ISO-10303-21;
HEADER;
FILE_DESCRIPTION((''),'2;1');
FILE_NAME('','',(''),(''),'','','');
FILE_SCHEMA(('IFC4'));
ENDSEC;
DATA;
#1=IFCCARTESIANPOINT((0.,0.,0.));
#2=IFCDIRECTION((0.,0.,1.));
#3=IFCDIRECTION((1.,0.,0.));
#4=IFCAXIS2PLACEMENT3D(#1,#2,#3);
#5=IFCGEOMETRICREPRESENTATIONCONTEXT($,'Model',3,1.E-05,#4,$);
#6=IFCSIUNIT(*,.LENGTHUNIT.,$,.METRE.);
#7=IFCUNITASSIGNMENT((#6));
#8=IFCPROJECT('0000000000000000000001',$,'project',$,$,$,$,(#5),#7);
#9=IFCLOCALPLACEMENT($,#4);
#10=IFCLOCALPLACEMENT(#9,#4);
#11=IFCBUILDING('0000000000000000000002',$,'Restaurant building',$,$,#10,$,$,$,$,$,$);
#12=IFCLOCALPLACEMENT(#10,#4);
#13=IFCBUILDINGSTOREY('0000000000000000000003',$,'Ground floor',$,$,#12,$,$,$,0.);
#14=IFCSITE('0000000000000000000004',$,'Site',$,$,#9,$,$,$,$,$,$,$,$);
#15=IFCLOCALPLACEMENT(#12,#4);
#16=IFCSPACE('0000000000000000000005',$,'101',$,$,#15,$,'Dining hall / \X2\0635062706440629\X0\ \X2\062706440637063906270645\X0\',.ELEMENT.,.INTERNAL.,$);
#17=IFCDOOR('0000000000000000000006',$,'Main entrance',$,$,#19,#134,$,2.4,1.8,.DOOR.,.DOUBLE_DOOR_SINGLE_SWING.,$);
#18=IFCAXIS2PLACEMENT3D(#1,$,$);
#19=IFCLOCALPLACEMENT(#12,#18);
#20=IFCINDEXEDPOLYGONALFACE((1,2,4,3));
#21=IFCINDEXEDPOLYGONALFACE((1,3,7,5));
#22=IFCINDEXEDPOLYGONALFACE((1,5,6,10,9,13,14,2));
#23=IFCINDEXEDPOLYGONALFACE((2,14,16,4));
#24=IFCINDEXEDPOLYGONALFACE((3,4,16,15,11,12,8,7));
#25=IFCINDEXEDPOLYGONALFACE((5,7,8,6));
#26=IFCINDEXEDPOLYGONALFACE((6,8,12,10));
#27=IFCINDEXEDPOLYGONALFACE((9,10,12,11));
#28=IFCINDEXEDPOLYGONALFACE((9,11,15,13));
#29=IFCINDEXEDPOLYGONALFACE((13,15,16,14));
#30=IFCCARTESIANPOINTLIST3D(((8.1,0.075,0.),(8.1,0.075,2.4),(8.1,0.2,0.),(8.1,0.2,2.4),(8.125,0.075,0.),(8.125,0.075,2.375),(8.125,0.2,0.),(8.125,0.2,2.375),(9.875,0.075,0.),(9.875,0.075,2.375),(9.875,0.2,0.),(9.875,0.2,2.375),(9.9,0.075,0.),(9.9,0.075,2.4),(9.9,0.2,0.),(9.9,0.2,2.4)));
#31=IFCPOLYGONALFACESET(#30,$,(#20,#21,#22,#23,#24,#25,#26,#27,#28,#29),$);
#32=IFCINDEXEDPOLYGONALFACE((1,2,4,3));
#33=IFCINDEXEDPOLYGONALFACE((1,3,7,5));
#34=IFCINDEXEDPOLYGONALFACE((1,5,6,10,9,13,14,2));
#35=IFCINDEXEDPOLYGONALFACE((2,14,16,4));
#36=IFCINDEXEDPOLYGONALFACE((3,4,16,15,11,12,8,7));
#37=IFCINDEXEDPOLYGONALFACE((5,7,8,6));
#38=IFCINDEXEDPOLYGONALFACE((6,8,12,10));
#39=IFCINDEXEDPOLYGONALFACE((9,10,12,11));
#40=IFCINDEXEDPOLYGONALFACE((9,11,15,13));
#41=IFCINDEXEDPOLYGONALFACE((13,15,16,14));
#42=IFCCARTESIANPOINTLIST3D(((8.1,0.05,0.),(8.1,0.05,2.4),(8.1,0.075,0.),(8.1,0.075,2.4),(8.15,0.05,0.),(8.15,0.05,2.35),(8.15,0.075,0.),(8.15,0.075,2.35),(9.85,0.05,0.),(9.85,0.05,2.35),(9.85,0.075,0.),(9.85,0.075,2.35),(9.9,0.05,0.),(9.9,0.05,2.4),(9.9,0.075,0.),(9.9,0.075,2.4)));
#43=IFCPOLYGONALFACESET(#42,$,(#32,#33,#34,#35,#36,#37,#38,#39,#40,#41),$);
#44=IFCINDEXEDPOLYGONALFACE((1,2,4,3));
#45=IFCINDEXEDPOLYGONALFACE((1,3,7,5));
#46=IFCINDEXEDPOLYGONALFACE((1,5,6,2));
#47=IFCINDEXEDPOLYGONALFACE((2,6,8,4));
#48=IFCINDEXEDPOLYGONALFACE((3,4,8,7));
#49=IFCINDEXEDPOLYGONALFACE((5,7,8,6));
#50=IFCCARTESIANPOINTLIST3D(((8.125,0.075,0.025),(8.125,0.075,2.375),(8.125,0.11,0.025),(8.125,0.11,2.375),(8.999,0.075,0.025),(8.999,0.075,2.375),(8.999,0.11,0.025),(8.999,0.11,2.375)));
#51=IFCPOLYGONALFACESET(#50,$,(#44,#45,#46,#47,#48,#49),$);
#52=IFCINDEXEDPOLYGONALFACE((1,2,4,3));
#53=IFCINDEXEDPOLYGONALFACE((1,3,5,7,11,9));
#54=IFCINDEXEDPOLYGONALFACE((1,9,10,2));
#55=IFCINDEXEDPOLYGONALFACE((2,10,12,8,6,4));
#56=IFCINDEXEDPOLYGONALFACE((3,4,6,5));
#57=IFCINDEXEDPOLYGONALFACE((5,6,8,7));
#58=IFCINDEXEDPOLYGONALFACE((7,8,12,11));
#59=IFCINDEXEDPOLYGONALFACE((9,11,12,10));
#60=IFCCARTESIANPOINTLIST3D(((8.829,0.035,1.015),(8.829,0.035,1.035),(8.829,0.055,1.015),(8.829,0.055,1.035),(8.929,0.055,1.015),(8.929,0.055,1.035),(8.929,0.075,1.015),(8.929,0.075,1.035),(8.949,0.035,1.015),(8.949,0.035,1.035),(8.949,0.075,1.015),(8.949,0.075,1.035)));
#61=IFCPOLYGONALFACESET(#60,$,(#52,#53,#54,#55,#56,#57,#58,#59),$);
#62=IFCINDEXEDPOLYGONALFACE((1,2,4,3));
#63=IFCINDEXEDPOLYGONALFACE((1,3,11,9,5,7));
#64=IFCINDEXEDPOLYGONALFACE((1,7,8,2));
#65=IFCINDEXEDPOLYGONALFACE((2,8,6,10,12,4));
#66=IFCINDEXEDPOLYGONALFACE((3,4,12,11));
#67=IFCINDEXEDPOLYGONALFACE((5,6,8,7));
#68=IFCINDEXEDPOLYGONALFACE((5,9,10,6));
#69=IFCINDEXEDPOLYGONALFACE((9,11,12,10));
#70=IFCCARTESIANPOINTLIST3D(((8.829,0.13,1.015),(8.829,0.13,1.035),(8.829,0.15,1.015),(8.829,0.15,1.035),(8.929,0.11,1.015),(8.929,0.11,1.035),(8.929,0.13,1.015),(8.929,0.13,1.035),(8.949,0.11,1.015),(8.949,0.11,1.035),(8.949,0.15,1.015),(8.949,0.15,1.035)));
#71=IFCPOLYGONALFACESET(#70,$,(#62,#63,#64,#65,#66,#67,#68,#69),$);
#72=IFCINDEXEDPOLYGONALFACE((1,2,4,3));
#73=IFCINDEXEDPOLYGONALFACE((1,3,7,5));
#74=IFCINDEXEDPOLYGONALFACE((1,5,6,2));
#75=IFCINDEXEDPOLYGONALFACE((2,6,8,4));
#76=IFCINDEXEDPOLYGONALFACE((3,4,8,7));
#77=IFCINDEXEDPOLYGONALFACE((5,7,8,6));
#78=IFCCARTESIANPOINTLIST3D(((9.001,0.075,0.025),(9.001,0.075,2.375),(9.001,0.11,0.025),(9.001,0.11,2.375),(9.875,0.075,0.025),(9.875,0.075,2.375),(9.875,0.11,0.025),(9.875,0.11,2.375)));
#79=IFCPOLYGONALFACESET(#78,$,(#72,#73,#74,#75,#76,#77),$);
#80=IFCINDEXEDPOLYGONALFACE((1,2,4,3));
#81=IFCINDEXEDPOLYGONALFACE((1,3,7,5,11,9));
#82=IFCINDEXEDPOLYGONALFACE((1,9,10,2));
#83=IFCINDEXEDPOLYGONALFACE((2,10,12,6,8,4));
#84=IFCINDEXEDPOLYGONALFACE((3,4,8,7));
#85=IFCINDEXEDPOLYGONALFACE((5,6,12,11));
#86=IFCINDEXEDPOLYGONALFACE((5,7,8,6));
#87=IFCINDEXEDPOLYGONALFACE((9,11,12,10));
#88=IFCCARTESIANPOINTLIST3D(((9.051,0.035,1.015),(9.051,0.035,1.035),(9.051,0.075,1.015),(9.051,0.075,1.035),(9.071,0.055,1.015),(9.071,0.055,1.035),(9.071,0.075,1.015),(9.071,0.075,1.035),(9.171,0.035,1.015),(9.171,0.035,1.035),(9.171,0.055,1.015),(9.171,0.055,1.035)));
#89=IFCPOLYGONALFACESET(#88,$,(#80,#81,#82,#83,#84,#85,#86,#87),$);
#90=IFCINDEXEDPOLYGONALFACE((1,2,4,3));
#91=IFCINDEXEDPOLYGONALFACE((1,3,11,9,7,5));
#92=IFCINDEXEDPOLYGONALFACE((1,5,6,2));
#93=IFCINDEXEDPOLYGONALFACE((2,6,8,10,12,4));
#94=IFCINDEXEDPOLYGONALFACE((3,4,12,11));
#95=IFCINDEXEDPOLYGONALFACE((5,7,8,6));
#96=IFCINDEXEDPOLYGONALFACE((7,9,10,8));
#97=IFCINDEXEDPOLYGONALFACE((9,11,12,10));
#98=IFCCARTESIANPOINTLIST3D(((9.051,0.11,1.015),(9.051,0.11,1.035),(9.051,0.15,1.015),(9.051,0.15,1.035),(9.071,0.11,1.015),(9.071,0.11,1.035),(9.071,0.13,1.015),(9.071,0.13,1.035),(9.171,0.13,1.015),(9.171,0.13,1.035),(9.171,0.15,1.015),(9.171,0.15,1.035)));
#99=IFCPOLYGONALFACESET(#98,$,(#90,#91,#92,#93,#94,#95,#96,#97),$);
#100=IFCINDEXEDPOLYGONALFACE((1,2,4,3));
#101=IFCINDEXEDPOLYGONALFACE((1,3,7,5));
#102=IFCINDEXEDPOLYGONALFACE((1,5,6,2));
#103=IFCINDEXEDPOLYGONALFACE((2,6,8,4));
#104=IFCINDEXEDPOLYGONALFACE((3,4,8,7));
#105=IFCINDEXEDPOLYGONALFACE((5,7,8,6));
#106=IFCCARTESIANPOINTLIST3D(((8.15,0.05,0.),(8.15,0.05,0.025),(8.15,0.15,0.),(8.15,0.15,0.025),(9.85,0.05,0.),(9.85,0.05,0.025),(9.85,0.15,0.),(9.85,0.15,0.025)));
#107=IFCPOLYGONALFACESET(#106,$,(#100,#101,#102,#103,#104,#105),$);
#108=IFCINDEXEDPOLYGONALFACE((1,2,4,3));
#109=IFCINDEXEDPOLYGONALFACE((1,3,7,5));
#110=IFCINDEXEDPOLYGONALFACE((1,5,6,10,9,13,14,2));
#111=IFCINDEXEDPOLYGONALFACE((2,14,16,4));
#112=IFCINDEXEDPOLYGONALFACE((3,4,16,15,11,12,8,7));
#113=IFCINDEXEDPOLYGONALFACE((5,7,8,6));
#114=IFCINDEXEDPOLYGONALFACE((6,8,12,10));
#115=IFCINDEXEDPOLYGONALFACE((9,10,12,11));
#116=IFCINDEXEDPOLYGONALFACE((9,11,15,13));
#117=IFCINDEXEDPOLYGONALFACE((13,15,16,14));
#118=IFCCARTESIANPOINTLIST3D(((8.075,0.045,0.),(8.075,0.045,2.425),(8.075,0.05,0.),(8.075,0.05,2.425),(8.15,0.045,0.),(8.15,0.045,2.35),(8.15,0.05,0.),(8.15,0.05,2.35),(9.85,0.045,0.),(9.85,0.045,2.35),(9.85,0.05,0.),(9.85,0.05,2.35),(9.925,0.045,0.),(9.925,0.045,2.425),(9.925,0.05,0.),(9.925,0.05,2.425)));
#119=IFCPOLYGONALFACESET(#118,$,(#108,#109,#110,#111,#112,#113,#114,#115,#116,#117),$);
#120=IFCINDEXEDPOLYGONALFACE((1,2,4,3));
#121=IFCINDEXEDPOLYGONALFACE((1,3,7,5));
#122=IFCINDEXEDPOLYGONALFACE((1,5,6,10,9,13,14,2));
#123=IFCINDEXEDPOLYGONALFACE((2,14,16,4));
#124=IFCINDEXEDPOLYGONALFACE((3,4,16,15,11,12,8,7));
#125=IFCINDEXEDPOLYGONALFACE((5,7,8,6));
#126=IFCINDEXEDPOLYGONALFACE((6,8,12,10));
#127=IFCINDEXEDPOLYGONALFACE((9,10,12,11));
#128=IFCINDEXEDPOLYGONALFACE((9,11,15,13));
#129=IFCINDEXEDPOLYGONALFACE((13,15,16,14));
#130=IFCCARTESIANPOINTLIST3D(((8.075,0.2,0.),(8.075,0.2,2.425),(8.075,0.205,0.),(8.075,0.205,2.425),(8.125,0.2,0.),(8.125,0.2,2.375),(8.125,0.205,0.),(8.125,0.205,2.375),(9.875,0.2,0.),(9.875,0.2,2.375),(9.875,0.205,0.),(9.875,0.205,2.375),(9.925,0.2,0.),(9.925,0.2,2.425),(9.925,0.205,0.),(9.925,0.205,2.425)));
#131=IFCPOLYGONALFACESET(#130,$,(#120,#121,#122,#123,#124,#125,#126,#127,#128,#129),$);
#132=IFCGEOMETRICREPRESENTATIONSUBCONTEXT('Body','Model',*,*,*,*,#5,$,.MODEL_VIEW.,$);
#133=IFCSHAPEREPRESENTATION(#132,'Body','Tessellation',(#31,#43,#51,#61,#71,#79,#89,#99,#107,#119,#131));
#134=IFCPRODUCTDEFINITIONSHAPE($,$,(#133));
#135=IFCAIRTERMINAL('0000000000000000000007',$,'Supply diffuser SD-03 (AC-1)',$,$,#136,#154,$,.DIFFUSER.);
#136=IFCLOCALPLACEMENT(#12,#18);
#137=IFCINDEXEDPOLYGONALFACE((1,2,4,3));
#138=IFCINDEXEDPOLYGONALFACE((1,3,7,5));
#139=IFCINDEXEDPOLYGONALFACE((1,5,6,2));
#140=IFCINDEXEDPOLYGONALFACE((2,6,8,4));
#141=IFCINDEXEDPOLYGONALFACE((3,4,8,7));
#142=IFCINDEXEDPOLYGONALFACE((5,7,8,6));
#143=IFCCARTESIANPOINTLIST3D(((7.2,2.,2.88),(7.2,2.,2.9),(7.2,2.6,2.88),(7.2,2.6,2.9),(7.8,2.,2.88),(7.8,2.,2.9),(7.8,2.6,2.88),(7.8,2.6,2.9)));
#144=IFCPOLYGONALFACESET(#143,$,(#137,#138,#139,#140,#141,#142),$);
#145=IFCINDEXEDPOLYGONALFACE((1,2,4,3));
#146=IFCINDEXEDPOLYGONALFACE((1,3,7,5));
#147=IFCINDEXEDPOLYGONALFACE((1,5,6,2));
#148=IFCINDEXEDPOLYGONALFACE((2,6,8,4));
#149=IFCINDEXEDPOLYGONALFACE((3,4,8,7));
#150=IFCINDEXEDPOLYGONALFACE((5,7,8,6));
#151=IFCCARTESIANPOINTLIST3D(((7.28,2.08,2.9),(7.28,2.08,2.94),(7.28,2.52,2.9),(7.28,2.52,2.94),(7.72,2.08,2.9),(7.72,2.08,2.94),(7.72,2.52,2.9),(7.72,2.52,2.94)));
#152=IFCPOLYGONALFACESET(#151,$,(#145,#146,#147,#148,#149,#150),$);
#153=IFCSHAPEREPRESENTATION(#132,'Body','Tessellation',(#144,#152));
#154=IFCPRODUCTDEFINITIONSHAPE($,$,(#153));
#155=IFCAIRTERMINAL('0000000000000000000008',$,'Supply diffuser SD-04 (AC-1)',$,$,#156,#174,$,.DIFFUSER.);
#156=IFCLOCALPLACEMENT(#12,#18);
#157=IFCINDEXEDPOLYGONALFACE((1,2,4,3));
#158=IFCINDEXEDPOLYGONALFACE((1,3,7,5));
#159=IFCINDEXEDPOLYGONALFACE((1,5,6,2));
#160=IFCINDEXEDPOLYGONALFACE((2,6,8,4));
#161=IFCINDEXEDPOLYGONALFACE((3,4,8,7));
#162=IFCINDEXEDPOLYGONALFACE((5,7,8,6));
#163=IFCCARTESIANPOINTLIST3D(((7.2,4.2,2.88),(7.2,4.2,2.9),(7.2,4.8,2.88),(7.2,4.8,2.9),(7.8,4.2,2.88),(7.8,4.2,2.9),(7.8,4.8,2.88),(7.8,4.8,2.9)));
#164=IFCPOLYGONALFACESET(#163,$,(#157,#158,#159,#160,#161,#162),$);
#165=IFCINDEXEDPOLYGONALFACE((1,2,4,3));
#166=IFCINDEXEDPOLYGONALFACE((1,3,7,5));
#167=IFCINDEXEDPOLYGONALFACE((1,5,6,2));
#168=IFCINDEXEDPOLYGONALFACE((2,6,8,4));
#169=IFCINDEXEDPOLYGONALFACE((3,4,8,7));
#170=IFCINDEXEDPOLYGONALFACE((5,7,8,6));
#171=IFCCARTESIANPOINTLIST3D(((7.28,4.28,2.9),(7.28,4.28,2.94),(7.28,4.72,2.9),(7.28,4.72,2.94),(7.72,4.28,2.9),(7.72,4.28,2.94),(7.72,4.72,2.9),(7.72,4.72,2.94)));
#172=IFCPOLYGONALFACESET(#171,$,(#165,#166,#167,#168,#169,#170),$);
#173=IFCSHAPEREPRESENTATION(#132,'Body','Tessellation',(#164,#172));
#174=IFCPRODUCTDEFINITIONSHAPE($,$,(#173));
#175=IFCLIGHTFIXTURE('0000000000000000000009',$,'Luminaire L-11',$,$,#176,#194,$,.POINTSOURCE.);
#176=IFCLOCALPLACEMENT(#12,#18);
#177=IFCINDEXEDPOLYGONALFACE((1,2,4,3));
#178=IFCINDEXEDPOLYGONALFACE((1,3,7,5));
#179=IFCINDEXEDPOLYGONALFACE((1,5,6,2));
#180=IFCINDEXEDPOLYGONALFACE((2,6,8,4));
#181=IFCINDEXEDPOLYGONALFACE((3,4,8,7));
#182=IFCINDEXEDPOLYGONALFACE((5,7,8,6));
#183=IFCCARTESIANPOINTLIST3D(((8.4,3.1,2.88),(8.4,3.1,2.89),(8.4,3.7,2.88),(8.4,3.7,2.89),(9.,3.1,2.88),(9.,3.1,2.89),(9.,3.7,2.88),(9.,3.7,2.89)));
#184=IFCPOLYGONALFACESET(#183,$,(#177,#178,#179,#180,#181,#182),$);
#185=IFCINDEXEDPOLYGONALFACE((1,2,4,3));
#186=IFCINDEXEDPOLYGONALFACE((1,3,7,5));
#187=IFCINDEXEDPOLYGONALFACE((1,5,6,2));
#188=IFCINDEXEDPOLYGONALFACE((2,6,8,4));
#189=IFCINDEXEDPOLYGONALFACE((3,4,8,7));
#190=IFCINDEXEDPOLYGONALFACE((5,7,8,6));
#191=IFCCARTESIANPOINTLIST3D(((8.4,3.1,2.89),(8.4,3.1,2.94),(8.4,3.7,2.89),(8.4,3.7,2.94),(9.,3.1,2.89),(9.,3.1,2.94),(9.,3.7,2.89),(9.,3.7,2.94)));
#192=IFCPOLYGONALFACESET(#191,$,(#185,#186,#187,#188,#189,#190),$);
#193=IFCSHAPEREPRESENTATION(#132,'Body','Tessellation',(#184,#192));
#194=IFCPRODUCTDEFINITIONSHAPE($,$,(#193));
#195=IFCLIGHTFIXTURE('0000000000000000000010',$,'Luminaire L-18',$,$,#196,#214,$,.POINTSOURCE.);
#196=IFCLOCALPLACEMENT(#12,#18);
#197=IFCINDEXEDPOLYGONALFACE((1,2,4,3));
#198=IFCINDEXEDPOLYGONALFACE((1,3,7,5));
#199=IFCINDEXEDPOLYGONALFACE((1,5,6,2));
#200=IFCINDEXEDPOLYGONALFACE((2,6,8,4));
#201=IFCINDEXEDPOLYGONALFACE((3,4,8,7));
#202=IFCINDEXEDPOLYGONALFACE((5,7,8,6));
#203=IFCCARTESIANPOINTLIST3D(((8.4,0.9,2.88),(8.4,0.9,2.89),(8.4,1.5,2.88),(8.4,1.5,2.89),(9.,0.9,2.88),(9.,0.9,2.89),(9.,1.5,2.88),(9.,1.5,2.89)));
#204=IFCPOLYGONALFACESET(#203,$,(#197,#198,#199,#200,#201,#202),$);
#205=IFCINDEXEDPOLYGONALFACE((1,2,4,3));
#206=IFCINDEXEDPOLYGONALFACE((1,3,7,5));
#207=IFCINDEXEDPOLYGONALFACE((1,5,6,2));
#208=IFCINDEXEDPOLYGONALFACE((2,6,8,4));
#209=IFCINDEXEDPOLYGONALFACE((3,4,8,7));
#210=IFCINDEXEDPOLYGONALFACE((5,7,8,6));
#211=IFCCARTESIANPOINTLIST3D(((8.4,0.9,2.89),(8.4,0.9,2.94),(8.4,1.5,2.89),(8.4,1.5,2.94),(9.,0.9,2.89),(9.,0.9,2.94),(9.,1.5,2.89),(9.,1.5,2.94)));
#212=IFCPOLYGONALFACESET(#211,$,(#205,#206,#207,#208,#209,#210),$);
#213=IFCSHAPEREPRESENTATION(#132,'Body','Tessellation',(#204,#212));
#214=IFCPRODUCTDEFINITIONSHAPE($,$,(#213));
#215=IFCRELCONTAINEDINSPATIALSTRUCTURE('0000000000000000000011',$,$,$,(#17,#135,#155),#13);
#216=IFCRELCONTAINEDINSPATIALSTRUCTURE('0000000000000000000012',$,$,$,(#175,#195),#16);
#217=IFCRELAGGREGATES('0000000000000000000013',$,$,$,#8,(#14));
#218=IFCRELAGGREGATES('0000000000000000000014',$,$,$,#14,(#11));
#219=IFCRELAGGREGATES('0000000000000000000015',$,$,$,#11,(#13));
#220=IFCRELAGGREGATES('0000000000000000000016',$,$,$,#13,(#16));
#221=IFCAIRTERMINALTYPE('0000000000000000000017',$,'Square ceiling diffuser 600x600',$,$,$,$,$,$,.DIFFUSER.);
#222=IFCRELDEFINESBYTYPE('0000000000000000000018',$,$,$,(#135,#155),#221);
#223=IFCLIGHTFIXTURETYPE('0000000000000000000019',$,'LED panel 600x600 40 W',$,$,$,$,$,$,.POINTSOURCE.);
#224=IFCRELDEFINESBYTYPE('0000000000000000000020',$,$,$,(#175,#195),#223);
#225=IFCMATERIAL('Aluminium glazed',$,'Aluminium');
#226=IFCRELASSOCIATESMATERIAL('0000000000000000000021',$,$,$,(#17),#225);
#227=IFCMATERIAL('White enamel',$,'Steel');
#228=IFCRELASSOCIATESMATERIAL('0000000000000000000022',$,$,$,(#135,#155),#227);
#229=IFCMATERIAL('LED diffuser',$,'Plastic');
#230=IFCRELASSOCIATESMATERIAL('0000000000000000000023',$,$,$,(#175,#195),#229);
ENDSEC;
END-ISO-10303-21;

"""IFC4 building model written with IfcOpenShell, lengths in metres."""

from ifc_helpers import new_model, si_unit, frame, origin, origin_with_axes, origin_2d, place, context, subcontext, project, spatial, line, indexed_curve, rectangle, outline, extrude, source, transform, mapped, material, type_object, type_shapes, element, save


model = new_model("IFC4")

# Units and contexts
model_context = context("Model", 3, precision=1e-05, world=origin_with_axes())
body_context = subcontext(model_context, "Body", "Model", "MODEL_VIEW")
ifc_project = project(units=[si_unit("LENGTHUNIT", "METRE")], contexts=[model_context])

# Site, building, storey
site_placement = place(None, origin_with_axes())
site = spatial("IfcSite", under=ifc_project, at=site_placement, Name="Site")
building_placement = place(site_placement, origin_with_axes())
building = spatial("IfcBuilding", under=site, at=building_placement, Name="Restaurant building")
storey_placement = place(building_placement, origin_with_axes())
storey = spatial("IfcBuildingStorey", under=building, at=storey_placement, Name="Ground floor", Elevation=0.0)

# Door
ifc_material_1 = material(Name="Aluminium glazed", Category="Aluminium")
door_placement = place(storey_placement, frame((8.1, 0.05, 0.0)))
element("IfcDoor", 1, at=door_placement, inside=storey, material=ifc_material_1, Name="Main entrance", OperationType="DOUBLE_DOOR_SINGLE_SWING", OverallHeight=2.4, OverallWidth=1.8, PredefinedType="DOOR", context=body_context, shape_type="SweptSolid", body=[
    extrude(outline(indexed_curve([(0.0, 0.0), (0.0, 2.4), (1.8, 2.4), (1.8, 0.0), (1.775, 0.0), (1.775, 2.375), (0.025, 2.375), (0.025, 0.0)], segments=[line(1, 2, 3, 4, 5, 6, 7, 8, 1)])), frame((0.0, 0.025, 0.0), z_axis=(0.0, -1.0, 0.0), x_axis=(1.0, 0.0, 0.0)), (0.0, 0.0, -1.0), 0.125),
    extrude(outline(indexed_curve([(0.0, 0.0), (0.0, 2.4), (1.8, 2.4), (1.8, 0.0), (1.75, 0.0), (1.75, 2.35), (0.05, 2.35), (0.05, 0.0)], segments=[line(1, 2, 3, 4, 5, 6, 7, 8, 1)])), frame((0.0, 0.0, 0.0), z_axis=(0.0, -1.0, 0.0), x_axis=(1.0, 0.0, 0.0)), (0.0, 0.0, -1.0), 0.025),
    extrude(outline(indexed_curve([(0.0, 0.0), (0.874, 0.0), (0.874, 0.035), (0.0, 0.035)], segments=[line(1, 2, 3, 4, 1)])), frame((0.025, 0.025, 0.025), z_axis=(0.0, 0.0, 1.0), x_axis=(1.0, 0.0, 0.0)), (0.0, 0.0, 1.0), 2.35),
    extrude(outline(indexed_curve([(0.0, 0.0), (0.0, -0.04), (-0.12, -0.04), (-0.12, -0.02), (-0.02, -0.02), (-0.02, 0.0)], segments=[line(1, 2, 3, 4, 5, 6, 1)])), frame((0.849, 0.025, 1.015), z_axis=(0.0, 0.0, 1.0), x_axis=(1.0, 0.0, 0.0)), (0.0, 0.0, 1.0), 0.02),
    extrude(outline(indexed_curve([(0.0, 0.0), (0.0, 0.04), (-0.12, 0.04), (-0.12, 0.02), (-0.02, 0.02), (-0.02, 0.0)], segments=[line(1, 2, 3, 4, 5, 6, 1)])), frame((0.849, 0.06, 1.015), z_axis=(0.0, 0.0, 1.0), x_axis=(1.0, 0.0, 0.0)), (0.0, 0.0, 1.0), 0.02),
    extrude(outline(indexed_curve([(0.0, 0.0), (-0.874, 0.0), (-0.874, 0.035), (0.0, 0.035)], segments=[line(1, 2, 3, 4, 1)])), frame((1.775, 0.025, 0.025), z_axis=(0.0, 0.0, 1.0), x_axis=(1.0, 0.0, 0.0)), (0.0, 0.0, 1.0), 2.35),
    extrude(outline(indexed_curve([(0.0, 0.0), (0.0, -0.04), (0.12, -0.04), (0.12, -0.02), (0.02, -0.02), (0.02, 0.0)], segments=[line(1, 2, 3, 4, 5, 6, 1)])), frame((0.951, 0.025, 1.015), z_axis=(0.0, 0.0, 1.0), x_axis=(1.0, 0.0, 0.0)), (0.0, 0.0, 1.0), 0.02),
    extrude(outline(indexed_curve([(0.0, 0.0), (0.0, 0.04), (0.12, 0.04), (0.12, 0.02), (0.02, 0.02), (0.02, 0.0)], segments=[line(1, 2, 3, 4, 5, 6, 1)])), frame((0.951, 0.06, 1.015), z_axis=(0.0, 0.0, 1.0), x_axis=(1.0, 0.0, 0.0)), (0.0, 0.0, 1.0), 0.02),
    extrude(outline(indexed_curve([(0.0, 0.0), (1.7, 0.0), (1.7, 0.1), (0.0, 0.1)], segments=[line(1, 2, 3, 4, 1)])), frame((0.05, 0.0, 0.0), z_axis=(0.0, 0.0, 1.0), x_axis=(1.0, 0.0, 0.0)), (0.0, 0.0, 1.0), 0.025),
    extrude(outline(indexed_curve([(0.0, 0.0), (0.0, 2.425), (1.85, 2.425), (1.85, 0.0), (1.775, 0.0), (1.775, 2.35), (0.075, 2.35), (0.075, 0.0)], segments=[line(1, 2, 3, 4, 5, 6, 7, 8, 1)])), frame((-0.025, -0.005, 0.0), z_axis=(0.0, -1.0, 0.0), x_axis=(1.0, 0.0, 0.0)), (0.0, 0.0, -1.0), 0.005),
    extrude(outline(indexed_curve([(0.0, 0.0), (0.0, 2.425), (1.85, 2.425), (1.85, 0.0), (1.8, 0.0), (1.8, 2.375), (0.05, 2.375), (0.05, 0.0)], segments=[line(1, 2, 3, 4, 5, 6, 7, 8, 1)])), frame((-0.025, 0.15, 0.0), z_axis=(0.0, -1.0, 0.0), x_axis=(1.0, 0.0, 0.0)), (0.0, 0.0, -1.0), 0.005),
])

# Air terminals
ifc_material_2 = material(Name="White enamel", Category="Steel")
air_terminal_type = type_object("IfcAirTerminalType", Name="Square ceiling diffuser 600x600", PredefinedType="DIFFUSER")
shared_shape_1 = source(origin(), body_context, "Body", "SweptSolid", [
    extrude(rectangle(XDim=0.6, YDim=0.6, at=origin_2d()), frame((0.0, 0.0, -0.06)), (0.0, 0.0, 1.0), 0.02),
    extrude(rectangle(XDim=0.44, YDim=0.44, at=origin_2d()), frame((0.0, 0.0, -0.04)), (0.0, 0.0, 1.0), 0.04),
])
type_shapes(air_terminal_type, [shared_shape_1])
for number, where, name in (
    (2, (7.5, 2.3, 2.94), "Supply diffuser SD-03 (AC-1)"),
    (3, (7.5, 4.5, 2.94), "Supply diffuser SD-04 (AC-1)"),
):
    element("IfcAirTerminal", number, at=place(storey_placement, frame(where)), inside=storey, type_object=air_terminal_type, material=ifc_material_2, Name=name, PredefinedType="DIFFUSER", context=body_context, shape_type="MappedRepresentation", body=[
        mapped(shared_shape_1, transform((0.0, 0.0, 0.0))),
    ])

# Shared definitions
space_placement = place(storey_placement, origin_with_axes())
space = spatial("IfcSpace", under=storey, at=space_placement, Name="101", LongName="Dining hall / صالة الطعام", CompositionType="ELEMENT", PredefinedType="INTERNAL")

# Light fixtures
ifc_material_3 = material(Name="LED diffuser", Category="Plastic")
light_fixture_type = type_object("IfcLightFixtureType", Name="LED panel 600x600 40 W", PredefinedType="POINTSOURCE")
shared_shape_2 = source(origin(), body_context, "Body", "SweptSolid", [
    extrude(rectangle(XDim=0.6, YDim=0.6, at=origin_2d()), frame((0.0, 0.0, -0.06)), (0.0, 0.0, 1.0), 0.01),
    extrude(rectangle(XDim=0.6, YDim=0.6, at=origin_2d()), frame((0.0, 0.0, -0.05)), (0.0, 0.0, 1.0), 0.05),
])
type_shapes(light_fixture_type, [shared_shape_2])
for number, where, name in (
    (4, (8.7, 3.4, 2.94), "Luminaire L-11"),
    (5, (8.7, 1.2, 2.94), "Luminaire L-18"),
):
    element("IfcLightFixture", number, at=place(storey_placement, frame(where)), inside=space, type_object=light_fixture_type, material=ifc_material_3, Name=name, PredefinedType="POINTSOURCE", context=body_context, shape_type="MappedRepresentation", body=[
        mapped(shared_shape_2, transform((0.0, 0.0, 0.0))),
    ])

save(model, "model.ifc")
